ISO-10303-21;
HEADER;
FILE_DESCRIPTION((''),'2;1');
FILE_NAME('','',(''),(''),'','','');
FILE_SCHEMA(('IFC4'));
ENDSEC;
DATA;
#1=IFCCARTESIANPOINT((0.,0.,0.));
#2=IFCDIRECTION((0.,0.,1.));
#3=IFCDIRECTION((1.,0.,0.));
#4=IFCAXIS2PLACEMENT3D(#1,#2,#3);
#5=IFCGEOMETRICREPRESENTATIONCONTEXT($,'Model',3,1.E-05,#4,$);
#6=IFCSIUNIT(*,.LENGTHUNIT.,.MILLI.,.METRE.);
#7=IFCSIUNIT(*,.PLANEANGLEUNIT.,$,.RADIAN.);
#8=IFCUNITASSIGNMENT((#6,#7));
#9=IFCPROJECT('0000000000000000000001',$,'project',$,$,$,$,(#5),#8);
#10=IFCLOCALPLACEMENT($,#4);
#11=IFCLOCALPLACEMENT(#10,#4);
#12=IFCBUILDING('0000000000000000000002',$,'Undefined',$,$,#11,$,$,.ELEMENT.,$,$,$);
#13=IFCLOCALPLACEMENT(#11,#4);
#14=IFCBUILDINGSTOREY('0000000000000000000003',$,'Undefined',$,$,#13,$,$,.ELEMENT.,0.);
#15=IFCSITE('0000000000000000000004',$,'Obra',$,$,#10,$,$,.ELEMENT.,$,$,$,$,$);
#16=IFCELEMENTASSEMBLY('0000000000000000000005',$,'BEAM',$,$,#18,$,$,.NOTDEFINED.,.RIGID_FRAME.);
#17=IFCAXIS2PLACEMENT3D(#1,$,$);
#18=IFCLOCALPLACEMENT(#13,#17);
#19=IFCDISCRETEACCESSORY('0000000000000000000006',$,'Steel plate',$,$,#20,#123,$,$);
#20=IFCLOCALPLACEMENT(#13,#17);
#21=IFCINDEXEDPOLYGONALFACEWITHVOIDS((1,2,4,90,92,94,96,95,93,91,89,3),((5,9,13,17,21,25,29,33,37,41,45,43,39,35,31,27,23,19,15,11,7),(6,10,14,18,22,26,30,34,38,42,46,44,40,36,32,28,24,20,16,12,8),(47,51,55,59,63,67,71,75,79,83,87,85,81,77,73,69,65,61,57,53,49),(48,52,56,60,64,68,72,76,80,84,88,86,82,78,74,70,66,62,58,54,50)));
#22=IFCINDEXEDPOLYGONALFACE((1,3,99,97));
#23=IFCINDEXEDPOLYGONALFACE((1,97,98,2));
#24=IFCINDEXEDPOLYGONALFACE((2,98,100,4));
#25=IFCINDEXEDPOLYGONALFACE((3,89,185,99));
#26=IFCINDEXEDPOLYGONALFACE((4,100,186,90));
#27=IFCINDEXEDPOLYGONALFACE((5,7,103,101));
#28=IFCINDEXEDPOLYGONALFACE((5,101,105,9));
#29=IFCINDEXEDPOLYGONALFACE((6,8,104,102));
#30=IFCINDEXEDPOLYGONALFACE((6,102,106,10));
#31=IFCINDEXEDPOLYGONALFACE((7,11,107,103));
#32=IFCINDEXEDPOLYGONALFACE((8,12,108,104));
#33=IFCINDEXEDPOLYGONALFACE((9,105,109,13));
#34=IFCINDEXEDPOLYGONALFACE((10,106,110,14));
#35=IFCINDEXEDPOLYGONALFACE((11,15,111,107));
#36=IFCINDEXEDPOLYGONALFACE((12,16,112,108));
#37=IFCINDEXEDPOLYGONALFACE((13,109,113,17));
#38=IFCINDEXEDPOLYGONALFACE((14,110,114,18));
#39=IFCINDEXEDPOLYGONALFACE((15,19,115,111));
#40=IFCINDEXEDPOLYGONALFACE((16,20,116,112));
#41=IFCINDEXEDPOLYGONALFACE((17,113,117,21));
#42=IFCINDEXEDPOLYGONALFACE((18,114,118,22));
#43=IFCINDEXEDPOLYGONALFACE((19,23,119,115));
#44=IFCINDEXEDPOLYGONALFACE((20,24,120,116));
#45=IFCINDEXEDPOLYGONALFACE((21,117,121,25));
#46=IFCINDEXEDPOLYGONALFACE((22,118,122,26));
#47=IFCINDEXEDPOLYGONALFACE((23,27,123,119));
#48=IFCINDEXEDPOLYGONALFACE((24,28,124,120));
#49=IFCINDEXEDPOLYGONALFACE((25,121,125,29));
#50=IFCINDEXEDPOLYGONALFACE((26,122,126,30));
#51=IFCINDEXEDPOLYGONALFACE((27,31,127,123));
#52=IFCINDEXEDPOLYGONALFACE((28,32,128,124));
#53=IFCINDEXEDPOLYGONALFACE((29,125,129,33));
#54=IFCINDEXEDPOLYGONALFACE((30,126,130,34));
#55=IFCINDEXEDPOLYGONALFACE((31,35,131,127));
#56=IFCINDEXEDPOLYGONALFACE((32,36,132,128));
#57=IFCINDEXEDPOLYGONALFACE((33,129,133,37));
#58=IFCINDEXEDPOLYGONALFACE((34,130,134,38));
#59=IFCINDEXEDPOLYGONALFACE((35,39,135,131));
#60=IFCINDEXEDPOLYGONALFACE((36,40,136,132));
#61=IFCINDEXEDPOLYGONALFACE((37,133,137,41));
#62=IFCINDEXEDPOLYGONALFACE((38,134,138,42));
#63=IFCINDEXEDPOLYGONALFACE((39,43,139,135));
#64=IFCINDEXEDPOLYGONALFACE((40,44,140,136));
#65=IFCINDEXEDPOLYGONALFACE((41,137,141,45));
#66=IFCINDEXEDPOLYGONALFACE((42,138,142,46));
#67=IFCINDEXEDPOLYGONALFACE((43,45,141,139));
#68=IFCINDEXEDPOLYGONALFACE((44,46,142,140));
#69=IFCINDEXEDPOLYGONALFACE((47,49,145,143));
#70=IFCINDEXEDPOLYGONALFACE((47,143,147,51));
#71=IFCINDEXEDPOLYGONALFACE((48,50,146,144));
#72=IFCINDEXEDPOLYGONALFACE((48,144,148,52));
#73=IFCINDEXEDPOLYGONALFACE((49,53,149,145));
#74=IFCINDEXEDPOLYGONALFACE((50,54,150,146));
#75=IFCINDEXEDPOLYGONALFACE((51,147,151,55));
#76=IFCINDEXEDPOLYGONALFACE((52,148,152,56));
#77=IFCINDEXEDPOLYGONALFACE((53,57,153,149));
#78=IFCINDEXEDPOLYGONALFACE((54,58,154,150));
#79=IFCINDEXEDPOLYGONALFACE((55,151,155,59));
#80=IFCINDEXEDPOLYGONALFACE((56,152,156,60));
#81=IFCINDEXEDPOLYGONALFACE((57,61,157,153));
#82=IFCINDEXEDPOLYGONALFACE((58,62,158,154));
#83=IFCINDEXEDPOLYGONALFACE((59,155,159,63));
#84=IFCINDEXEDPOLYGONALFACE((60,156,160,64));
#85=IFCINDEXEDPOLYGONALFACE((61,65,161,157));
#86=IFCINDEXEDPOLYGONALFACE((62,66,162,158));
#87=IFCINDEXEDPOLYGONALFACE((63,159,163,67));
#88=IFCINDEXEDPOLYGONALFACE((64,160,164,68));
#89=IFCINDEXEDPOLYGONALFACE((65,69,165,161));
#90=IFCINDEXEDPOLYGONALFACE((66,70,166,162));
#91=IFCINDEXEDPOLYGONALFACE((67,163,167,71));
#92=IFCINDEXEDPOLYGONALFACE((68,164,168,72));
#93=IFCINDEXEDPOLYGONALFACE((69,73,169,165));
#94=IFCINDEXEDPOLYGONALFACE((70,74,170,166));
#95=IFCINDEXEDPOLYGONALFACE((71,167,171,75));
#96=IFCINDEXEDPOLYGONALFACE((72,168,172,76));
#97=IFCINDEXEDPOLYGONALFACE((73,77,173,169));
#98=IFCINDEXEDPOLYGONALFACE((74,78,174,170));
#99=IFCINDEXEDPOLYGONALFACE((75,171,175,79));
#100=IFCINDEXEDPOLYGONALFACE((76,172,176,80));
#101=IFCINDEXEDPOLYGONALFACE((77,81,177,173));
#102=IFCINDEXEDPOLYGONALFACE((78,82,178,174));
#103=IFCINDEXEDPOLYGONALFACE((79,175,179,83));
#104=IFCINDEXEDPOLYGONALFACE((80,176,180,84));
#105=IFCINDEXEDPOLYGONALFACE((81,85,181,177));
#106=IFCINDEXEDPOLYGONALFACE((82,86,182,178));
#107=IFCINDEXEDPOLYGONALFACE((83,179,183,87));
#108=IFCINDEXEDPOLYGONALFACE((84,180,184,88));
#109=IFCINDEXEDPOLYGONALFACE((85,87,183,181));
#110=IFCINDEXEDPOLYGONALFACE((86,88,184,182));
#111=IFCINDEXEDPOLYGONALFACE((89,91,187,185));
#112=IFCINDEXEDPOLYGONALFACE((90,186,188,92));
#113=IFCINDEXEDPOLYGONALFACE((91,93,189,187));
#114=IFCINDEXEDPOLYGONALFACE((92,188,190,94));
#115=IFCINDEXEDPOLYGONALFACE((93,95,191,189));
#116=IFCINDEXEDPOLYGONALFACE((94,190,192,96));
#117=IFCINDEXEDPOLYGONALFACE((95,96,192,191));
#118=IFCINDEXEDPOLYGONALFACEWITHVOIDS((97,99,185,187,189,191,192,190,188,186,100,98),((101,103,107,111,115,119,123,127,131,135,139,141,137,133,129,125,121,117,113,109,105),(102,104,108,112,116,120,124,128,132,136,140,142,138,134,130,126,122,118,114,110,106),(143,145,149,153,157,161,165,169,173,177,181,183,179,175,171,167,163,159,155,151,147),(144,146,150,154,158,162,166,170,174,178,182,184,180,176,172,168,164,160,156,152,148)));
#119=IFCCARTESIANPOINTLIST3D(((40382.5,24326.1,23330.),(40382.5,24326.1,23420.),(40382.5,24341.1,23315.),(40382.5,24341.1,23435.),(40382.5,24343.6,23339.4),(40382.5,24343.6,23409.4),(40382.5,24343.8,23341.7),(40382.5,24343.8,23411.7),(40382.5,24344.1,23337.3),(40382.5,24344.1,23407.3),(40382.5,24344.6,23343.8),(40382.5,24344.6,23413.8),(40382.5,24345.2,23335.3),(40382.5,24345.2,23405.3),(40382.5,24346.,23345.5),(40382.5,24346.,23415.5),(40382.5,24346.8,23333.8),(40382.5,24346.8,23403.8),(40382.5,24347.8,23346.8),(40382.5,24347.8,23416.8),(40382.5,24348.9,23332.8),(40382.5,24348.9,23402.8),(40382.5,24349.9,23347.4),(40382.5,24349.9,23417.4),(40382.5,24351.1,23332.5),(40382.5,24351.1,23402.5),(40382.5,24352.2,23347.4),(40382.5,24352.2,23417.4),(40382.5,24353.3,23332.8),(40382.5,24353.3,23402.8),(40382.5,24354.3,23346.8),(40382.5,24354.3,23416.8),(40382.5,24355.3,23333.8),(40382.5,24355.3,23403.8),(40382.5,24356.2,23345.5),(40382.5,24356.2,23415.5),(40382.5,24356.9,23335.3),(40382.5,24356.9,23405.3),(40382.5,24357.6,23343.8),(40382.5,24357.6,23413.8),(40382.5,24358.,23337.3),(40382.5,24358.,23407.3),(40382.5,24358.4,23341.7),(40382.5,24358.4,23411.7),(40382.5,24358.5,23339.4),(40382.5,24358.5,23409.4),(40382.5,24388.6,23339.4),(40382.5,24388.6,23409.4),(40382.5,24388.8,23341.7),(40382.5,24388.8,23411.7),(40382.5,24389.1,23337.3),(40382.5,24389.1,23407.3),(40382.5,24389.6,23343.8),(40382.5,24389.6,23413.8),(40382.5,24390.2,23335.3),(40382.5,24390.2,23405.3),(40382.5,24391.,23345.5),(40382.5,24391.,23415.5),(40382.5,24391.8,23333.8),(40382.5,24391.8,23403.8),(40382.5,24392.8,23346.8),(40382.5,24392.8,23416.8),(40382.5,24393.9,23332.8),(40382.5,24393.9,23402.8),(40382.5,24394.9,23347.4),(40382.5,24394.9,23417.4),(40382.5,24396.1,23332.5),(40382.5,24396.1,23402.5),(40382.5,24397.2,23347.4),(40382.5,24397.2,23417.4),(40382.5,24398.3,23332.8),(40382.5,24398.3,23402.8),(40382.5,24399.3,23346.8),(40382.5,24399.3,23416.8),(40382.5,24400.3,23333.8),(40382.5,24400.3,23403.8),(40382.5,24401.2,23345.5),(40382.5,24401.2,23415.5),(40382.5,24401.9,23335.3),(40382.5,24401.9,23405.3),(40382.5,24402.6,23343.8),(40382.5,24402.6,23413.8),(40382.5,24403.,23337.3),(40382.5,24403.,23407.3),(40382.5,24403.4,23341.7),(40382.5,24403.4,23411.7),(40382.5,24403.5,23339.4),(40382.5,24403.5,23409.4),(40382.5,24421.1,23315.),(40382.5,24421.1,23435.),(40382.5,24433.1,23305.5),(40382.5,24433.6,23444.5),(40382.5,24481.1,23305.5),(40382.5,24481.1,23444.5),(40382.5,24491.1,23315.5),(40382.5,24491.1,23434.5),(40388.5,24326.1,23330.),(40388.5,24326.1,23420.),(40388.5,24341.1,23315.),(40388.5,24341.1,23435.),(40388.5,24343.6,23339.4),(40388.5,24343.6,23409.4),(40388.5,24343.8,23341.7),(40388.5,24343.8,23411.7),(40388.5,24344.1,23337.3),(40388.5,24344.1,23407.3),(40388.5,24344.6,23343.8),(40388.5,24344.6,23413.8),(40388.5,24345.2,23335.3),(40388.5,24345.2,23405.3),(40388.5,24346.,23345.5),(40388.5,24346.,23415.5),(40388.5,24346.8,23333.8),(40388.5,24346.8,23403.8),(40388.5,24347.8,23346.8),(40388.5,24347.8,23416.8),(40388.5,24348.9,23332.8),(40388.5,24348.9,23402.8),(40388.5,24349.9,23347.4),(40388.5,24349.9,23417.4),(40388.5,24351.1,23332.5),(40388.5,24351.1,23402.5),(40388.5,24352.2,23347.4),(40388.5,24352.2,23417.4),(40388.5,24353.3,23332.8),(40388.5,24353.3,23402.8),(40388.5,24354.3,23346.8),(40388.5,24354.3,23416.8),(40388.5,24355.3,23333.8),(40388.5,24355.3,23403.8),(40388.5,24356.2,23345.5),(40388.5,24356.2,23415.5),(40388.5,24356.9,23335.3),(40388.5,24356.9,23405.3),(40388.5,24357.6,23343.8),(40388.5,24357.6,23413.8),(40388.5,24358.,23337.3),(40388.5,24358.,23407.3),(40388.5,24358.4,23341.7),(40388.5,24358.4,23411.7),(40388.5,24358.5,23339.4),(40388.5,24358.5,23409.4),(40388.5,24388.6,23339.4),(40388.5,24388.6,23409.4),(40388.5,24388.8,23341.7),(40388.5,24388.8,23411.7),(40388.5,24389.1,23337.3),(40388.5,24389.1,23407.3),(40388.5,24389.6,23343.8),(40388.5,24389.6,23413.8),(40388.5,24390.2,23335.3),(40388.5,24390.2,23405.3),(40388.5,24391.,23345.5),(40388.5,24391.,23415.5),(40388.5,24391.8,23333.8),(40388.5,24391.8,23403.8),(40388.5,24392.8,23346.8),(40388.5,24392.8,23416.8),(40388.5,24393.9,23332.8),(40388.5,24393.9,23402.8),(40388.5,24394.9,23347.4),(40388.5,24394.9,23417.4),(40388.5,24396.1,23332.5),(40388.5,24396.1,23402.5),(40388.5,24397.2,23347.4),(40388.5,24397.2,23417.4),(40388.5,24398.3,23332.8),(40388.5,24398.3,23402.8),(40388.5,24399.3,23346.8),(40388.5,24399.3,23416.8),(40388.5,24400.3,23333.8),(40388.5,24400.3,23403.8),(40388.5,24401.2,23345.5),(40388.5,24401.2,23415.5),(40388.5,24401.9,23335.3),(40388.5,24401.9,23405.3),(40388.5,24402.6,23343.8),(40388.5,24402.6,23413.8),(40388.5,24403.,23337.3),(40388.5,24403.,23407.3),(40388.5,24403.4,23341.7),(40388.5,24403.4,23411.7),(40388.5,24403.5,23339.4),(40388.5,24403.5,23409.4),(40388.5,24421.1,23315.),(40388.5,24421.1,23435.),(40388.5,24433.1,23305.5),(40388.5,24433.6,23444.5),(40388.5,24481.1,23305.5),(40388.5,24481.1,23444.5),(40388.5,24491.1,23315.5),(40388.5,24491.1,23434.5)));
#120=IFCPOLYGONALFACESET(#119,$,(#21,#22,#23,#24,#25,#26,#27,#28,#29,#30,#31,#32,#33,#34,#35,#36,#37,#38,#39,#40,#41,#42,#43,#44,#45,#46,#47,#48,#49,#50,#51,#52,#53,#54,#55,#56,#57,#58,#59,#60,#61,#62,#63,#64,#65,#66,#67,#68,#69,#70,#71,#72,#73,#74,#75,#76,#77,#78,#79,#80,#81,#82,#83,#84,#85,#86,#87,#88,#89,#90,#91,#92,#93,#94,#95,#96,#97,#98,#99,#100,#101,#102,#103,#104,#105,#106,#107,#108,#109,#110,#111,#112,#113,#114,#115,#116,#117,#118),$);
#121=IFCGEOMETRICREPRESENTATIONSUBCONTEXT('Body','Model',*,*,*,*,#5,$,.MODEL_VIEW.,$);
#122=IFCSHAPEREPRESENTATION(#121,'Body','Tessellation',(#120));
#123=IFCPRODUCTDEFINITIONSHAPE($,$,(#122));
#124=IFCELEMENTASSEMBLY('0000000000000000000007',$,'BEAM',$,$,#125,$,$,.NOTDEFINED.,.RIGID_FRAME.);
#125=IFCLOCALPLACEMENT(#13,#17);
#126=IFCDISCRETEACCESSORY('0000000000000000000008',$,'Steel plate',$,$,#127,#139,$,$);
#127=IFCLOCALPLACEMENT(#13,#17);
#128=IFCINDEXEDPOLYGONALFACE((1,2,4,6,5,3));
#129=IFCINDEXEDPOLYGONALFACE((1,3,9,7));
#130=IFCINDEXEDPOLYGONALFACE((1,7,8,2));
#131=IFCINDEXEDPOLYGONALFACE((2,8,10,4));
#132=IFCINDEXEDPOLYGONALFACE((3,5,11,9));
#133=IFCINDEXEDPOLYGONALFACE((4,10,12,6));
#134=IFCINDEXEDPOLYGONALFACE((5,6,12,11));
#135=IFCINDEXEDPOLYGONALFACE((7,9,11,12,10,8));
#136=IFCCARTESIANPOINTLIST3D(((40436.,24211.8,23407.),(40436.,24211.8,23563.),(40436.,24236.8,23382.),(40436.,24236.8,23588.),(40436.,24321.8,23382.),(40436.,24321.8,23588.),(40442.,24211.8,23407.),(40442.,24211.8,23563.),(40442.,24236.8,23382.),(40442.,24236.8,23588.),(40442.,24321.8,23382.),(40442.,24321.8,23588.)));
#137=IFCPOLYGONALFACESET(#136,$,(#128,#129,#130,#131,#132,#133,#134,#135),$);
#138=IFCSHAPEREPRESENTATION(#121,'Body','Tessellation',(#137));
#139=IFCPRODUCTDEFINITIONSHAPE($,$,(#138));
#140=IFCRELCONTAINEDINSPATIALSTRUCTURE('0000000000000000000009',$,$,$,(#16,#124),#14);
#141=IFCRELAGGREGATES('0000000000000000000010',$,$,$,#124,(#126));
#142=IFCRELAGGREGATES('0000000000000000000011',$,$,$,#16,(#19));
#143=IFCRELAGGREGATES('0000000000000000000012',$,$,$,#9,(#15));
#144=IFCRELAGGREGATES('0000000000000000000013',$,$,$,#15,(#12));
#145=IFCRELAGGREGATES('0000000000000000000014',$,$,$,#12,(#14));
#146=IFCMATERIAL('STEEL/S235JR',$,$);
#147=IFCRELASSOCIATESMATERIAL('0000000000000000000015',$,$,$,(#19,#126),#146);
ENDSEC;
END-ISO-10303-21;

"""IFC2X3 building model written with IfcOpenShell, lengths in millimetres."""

from ifc_helpers import new_model, si_unit, frame, origin_with_axes, origin_2d_with_axis, place, context, subcontext, project, spatial, polyline, circle, outline, extrude, source, transform, mapped, material, element, aggregate, save


model = new_model("IFC2X3")

# Units and contexts
model_context = context("Model", 3, precision=1e-05, world=origin_with_axes())
body_context = subcontext(model_context, "Body", "Model", "MODEL_VIEW")
ifc_project = project(units=[si_unit("LENGTHUNIT", "METRE", prefix="MILLI"), si_unit("PLANEANGLEUNIT", "RADIAN")], contexts=[model_context])

# Site, building, storey
site_placement = place(None, origin_with_axes())
site = spatial("IfcSite", under=ifc_project, at=site_placement, Name="Obra", CompositionType="ELEMENT")
building_placement = place(site_placement, origin_with_axes())
building = spatial("IfcBuilding", under=site, at=building_placement, Name="Undefined", CompositionType="ELEMENT")
storey_placement = place(building_placement, origin_with_axes())
storey = spatial("IfcBuildingStorey", under=building, at=storey_placement, Name="Undefined", CompositionType="ELEMENT", Elevation=0.0)

# Element assembly
assembly_1_placement = place(storey_placement, origin_with_axes())
assembly_1 = element("IfcElementAssembly", 1, at=assembly_1_placement, inside=storey, Name="BEAM", AssemblyPlace="NOTDEFINED", PredefinedType="RIGID_FRAME")

# Shared definitions
ifc_material_1 = material(Name="STEEL/S235JR")

# Discrete accessory, opening
discrete_accessory_1_placement = place(assembly_1_placement, frame((40385.5, 24491.1, 23315.5), z_axis=(-1.0, 0.0, 0.0), x_axis=(0.000001, -0.707107, -0.707107)))
discrete_accessory_1 = element("IfcDiscreteAccessory", 2, at=discrete_accessory_1_placement, material=ifc_material_1, Name="Steel plate", context=body_context, shape_type="SweptSolid", body=[
    extrude(outline(polyline([(0.0, 0.0), (14.1, 0.0), (48.1, 33.9), (49.9, 49.1), (106.4, 105.7), (106.4, 126.9), (42.8, 190.6), (21.6, 190.6), (-35.0, 134.0), (-50.6, 131.9), (-84.1, 98.3), (-84.1, 84.1), (0.0, 0.0)])), frame((0.0, 0.0, -3.0), z_axis=(0.0, 0.0, 1.0), x_axis=(1.0, 0.0, 0.0)), (0.0, 0.0, 1.0), 6.0),
])
shared_shape_1 = source(origin_with_axes(), body_context, "Body", "SweptSolid", [
    extrude(circle(Radius=7.5, at=origin_2d_with_axis()), frame((0.0, 2.4, 0.0), z_axis=(0.0, 1.0, 0.0), x_axis=(1.0, 0.0, 0.0)), (0.0, 0.0, 1.0), 6.2),
])
opening_1_placement = place(assembly_1_placement, frame((40380.0, 24373.6, 23410.0), z_axis=(0.0, -1.0, 0.0), x_axis=(0.0, 0.0, -1.0)))
element("IfcOpeningElement", 3, at=opening_1_placement, cuts=discrete_accessory_1, ObjectType="Opening", context=body_context, shape_type="MappedRepresentation", body=[
    mapped(shared_shape_1, transform((0.0, 0.0, -22.5))),
    mapped(shared_shape_1, transform((70.0, 0.0, -22.5))),
    mapped(shared_shape_1, transform((0.0, 0.0, 22.5))),
    mapped(shared_shape_1, transform((70.0, 0.0, 22.5))),
])

# Element assembly, discrete accessory
assembly_2_placement = place(storey_placement, origin_with_axes())
assembly_2 = element("IfcElementAssembly", 4, at=assembly_2_placement, inside=storey, Name="BEAM", AssemblyPlace="NOTDEFINED", PredefinedType="RIGID_FRAME")
discrete_accessory_2_placement = place(assembly_2_placement, frame((40439.0, 24211.8, 23382.0), z_axis=(1.0, 0.0, 0.0), x_axis=(0.0, 1.0, 0.0)))
discrete_accessory_2 = element("IfcDiscreteAccessory", 5, at=discrete_accessory_2_placement, material=ifc_material_1, Name="Steel plate", context=body_context, shape_type="SweptSolid", body=[
    extrude(outline(polyline([(0.0, 25.0), (25.0, 0.0), (110.0, 0.0), (110.0, 206.0), (25.0, 206.0), (0.0, 181.0), (0.0, 25.0)])), frame((0.0, 0.0, -3.0), z_axis=(0.0, 0.0, 1.0), x_axis=(1.0, 0.0, 0.0)), (0.0, 0.0, 1.0), 6.0),
])
aggregate(assembly_2, [discrete_accessory_2])

aggregate(assembly_1, [discrete_accessory_1])

save(model, "model.ifc")
